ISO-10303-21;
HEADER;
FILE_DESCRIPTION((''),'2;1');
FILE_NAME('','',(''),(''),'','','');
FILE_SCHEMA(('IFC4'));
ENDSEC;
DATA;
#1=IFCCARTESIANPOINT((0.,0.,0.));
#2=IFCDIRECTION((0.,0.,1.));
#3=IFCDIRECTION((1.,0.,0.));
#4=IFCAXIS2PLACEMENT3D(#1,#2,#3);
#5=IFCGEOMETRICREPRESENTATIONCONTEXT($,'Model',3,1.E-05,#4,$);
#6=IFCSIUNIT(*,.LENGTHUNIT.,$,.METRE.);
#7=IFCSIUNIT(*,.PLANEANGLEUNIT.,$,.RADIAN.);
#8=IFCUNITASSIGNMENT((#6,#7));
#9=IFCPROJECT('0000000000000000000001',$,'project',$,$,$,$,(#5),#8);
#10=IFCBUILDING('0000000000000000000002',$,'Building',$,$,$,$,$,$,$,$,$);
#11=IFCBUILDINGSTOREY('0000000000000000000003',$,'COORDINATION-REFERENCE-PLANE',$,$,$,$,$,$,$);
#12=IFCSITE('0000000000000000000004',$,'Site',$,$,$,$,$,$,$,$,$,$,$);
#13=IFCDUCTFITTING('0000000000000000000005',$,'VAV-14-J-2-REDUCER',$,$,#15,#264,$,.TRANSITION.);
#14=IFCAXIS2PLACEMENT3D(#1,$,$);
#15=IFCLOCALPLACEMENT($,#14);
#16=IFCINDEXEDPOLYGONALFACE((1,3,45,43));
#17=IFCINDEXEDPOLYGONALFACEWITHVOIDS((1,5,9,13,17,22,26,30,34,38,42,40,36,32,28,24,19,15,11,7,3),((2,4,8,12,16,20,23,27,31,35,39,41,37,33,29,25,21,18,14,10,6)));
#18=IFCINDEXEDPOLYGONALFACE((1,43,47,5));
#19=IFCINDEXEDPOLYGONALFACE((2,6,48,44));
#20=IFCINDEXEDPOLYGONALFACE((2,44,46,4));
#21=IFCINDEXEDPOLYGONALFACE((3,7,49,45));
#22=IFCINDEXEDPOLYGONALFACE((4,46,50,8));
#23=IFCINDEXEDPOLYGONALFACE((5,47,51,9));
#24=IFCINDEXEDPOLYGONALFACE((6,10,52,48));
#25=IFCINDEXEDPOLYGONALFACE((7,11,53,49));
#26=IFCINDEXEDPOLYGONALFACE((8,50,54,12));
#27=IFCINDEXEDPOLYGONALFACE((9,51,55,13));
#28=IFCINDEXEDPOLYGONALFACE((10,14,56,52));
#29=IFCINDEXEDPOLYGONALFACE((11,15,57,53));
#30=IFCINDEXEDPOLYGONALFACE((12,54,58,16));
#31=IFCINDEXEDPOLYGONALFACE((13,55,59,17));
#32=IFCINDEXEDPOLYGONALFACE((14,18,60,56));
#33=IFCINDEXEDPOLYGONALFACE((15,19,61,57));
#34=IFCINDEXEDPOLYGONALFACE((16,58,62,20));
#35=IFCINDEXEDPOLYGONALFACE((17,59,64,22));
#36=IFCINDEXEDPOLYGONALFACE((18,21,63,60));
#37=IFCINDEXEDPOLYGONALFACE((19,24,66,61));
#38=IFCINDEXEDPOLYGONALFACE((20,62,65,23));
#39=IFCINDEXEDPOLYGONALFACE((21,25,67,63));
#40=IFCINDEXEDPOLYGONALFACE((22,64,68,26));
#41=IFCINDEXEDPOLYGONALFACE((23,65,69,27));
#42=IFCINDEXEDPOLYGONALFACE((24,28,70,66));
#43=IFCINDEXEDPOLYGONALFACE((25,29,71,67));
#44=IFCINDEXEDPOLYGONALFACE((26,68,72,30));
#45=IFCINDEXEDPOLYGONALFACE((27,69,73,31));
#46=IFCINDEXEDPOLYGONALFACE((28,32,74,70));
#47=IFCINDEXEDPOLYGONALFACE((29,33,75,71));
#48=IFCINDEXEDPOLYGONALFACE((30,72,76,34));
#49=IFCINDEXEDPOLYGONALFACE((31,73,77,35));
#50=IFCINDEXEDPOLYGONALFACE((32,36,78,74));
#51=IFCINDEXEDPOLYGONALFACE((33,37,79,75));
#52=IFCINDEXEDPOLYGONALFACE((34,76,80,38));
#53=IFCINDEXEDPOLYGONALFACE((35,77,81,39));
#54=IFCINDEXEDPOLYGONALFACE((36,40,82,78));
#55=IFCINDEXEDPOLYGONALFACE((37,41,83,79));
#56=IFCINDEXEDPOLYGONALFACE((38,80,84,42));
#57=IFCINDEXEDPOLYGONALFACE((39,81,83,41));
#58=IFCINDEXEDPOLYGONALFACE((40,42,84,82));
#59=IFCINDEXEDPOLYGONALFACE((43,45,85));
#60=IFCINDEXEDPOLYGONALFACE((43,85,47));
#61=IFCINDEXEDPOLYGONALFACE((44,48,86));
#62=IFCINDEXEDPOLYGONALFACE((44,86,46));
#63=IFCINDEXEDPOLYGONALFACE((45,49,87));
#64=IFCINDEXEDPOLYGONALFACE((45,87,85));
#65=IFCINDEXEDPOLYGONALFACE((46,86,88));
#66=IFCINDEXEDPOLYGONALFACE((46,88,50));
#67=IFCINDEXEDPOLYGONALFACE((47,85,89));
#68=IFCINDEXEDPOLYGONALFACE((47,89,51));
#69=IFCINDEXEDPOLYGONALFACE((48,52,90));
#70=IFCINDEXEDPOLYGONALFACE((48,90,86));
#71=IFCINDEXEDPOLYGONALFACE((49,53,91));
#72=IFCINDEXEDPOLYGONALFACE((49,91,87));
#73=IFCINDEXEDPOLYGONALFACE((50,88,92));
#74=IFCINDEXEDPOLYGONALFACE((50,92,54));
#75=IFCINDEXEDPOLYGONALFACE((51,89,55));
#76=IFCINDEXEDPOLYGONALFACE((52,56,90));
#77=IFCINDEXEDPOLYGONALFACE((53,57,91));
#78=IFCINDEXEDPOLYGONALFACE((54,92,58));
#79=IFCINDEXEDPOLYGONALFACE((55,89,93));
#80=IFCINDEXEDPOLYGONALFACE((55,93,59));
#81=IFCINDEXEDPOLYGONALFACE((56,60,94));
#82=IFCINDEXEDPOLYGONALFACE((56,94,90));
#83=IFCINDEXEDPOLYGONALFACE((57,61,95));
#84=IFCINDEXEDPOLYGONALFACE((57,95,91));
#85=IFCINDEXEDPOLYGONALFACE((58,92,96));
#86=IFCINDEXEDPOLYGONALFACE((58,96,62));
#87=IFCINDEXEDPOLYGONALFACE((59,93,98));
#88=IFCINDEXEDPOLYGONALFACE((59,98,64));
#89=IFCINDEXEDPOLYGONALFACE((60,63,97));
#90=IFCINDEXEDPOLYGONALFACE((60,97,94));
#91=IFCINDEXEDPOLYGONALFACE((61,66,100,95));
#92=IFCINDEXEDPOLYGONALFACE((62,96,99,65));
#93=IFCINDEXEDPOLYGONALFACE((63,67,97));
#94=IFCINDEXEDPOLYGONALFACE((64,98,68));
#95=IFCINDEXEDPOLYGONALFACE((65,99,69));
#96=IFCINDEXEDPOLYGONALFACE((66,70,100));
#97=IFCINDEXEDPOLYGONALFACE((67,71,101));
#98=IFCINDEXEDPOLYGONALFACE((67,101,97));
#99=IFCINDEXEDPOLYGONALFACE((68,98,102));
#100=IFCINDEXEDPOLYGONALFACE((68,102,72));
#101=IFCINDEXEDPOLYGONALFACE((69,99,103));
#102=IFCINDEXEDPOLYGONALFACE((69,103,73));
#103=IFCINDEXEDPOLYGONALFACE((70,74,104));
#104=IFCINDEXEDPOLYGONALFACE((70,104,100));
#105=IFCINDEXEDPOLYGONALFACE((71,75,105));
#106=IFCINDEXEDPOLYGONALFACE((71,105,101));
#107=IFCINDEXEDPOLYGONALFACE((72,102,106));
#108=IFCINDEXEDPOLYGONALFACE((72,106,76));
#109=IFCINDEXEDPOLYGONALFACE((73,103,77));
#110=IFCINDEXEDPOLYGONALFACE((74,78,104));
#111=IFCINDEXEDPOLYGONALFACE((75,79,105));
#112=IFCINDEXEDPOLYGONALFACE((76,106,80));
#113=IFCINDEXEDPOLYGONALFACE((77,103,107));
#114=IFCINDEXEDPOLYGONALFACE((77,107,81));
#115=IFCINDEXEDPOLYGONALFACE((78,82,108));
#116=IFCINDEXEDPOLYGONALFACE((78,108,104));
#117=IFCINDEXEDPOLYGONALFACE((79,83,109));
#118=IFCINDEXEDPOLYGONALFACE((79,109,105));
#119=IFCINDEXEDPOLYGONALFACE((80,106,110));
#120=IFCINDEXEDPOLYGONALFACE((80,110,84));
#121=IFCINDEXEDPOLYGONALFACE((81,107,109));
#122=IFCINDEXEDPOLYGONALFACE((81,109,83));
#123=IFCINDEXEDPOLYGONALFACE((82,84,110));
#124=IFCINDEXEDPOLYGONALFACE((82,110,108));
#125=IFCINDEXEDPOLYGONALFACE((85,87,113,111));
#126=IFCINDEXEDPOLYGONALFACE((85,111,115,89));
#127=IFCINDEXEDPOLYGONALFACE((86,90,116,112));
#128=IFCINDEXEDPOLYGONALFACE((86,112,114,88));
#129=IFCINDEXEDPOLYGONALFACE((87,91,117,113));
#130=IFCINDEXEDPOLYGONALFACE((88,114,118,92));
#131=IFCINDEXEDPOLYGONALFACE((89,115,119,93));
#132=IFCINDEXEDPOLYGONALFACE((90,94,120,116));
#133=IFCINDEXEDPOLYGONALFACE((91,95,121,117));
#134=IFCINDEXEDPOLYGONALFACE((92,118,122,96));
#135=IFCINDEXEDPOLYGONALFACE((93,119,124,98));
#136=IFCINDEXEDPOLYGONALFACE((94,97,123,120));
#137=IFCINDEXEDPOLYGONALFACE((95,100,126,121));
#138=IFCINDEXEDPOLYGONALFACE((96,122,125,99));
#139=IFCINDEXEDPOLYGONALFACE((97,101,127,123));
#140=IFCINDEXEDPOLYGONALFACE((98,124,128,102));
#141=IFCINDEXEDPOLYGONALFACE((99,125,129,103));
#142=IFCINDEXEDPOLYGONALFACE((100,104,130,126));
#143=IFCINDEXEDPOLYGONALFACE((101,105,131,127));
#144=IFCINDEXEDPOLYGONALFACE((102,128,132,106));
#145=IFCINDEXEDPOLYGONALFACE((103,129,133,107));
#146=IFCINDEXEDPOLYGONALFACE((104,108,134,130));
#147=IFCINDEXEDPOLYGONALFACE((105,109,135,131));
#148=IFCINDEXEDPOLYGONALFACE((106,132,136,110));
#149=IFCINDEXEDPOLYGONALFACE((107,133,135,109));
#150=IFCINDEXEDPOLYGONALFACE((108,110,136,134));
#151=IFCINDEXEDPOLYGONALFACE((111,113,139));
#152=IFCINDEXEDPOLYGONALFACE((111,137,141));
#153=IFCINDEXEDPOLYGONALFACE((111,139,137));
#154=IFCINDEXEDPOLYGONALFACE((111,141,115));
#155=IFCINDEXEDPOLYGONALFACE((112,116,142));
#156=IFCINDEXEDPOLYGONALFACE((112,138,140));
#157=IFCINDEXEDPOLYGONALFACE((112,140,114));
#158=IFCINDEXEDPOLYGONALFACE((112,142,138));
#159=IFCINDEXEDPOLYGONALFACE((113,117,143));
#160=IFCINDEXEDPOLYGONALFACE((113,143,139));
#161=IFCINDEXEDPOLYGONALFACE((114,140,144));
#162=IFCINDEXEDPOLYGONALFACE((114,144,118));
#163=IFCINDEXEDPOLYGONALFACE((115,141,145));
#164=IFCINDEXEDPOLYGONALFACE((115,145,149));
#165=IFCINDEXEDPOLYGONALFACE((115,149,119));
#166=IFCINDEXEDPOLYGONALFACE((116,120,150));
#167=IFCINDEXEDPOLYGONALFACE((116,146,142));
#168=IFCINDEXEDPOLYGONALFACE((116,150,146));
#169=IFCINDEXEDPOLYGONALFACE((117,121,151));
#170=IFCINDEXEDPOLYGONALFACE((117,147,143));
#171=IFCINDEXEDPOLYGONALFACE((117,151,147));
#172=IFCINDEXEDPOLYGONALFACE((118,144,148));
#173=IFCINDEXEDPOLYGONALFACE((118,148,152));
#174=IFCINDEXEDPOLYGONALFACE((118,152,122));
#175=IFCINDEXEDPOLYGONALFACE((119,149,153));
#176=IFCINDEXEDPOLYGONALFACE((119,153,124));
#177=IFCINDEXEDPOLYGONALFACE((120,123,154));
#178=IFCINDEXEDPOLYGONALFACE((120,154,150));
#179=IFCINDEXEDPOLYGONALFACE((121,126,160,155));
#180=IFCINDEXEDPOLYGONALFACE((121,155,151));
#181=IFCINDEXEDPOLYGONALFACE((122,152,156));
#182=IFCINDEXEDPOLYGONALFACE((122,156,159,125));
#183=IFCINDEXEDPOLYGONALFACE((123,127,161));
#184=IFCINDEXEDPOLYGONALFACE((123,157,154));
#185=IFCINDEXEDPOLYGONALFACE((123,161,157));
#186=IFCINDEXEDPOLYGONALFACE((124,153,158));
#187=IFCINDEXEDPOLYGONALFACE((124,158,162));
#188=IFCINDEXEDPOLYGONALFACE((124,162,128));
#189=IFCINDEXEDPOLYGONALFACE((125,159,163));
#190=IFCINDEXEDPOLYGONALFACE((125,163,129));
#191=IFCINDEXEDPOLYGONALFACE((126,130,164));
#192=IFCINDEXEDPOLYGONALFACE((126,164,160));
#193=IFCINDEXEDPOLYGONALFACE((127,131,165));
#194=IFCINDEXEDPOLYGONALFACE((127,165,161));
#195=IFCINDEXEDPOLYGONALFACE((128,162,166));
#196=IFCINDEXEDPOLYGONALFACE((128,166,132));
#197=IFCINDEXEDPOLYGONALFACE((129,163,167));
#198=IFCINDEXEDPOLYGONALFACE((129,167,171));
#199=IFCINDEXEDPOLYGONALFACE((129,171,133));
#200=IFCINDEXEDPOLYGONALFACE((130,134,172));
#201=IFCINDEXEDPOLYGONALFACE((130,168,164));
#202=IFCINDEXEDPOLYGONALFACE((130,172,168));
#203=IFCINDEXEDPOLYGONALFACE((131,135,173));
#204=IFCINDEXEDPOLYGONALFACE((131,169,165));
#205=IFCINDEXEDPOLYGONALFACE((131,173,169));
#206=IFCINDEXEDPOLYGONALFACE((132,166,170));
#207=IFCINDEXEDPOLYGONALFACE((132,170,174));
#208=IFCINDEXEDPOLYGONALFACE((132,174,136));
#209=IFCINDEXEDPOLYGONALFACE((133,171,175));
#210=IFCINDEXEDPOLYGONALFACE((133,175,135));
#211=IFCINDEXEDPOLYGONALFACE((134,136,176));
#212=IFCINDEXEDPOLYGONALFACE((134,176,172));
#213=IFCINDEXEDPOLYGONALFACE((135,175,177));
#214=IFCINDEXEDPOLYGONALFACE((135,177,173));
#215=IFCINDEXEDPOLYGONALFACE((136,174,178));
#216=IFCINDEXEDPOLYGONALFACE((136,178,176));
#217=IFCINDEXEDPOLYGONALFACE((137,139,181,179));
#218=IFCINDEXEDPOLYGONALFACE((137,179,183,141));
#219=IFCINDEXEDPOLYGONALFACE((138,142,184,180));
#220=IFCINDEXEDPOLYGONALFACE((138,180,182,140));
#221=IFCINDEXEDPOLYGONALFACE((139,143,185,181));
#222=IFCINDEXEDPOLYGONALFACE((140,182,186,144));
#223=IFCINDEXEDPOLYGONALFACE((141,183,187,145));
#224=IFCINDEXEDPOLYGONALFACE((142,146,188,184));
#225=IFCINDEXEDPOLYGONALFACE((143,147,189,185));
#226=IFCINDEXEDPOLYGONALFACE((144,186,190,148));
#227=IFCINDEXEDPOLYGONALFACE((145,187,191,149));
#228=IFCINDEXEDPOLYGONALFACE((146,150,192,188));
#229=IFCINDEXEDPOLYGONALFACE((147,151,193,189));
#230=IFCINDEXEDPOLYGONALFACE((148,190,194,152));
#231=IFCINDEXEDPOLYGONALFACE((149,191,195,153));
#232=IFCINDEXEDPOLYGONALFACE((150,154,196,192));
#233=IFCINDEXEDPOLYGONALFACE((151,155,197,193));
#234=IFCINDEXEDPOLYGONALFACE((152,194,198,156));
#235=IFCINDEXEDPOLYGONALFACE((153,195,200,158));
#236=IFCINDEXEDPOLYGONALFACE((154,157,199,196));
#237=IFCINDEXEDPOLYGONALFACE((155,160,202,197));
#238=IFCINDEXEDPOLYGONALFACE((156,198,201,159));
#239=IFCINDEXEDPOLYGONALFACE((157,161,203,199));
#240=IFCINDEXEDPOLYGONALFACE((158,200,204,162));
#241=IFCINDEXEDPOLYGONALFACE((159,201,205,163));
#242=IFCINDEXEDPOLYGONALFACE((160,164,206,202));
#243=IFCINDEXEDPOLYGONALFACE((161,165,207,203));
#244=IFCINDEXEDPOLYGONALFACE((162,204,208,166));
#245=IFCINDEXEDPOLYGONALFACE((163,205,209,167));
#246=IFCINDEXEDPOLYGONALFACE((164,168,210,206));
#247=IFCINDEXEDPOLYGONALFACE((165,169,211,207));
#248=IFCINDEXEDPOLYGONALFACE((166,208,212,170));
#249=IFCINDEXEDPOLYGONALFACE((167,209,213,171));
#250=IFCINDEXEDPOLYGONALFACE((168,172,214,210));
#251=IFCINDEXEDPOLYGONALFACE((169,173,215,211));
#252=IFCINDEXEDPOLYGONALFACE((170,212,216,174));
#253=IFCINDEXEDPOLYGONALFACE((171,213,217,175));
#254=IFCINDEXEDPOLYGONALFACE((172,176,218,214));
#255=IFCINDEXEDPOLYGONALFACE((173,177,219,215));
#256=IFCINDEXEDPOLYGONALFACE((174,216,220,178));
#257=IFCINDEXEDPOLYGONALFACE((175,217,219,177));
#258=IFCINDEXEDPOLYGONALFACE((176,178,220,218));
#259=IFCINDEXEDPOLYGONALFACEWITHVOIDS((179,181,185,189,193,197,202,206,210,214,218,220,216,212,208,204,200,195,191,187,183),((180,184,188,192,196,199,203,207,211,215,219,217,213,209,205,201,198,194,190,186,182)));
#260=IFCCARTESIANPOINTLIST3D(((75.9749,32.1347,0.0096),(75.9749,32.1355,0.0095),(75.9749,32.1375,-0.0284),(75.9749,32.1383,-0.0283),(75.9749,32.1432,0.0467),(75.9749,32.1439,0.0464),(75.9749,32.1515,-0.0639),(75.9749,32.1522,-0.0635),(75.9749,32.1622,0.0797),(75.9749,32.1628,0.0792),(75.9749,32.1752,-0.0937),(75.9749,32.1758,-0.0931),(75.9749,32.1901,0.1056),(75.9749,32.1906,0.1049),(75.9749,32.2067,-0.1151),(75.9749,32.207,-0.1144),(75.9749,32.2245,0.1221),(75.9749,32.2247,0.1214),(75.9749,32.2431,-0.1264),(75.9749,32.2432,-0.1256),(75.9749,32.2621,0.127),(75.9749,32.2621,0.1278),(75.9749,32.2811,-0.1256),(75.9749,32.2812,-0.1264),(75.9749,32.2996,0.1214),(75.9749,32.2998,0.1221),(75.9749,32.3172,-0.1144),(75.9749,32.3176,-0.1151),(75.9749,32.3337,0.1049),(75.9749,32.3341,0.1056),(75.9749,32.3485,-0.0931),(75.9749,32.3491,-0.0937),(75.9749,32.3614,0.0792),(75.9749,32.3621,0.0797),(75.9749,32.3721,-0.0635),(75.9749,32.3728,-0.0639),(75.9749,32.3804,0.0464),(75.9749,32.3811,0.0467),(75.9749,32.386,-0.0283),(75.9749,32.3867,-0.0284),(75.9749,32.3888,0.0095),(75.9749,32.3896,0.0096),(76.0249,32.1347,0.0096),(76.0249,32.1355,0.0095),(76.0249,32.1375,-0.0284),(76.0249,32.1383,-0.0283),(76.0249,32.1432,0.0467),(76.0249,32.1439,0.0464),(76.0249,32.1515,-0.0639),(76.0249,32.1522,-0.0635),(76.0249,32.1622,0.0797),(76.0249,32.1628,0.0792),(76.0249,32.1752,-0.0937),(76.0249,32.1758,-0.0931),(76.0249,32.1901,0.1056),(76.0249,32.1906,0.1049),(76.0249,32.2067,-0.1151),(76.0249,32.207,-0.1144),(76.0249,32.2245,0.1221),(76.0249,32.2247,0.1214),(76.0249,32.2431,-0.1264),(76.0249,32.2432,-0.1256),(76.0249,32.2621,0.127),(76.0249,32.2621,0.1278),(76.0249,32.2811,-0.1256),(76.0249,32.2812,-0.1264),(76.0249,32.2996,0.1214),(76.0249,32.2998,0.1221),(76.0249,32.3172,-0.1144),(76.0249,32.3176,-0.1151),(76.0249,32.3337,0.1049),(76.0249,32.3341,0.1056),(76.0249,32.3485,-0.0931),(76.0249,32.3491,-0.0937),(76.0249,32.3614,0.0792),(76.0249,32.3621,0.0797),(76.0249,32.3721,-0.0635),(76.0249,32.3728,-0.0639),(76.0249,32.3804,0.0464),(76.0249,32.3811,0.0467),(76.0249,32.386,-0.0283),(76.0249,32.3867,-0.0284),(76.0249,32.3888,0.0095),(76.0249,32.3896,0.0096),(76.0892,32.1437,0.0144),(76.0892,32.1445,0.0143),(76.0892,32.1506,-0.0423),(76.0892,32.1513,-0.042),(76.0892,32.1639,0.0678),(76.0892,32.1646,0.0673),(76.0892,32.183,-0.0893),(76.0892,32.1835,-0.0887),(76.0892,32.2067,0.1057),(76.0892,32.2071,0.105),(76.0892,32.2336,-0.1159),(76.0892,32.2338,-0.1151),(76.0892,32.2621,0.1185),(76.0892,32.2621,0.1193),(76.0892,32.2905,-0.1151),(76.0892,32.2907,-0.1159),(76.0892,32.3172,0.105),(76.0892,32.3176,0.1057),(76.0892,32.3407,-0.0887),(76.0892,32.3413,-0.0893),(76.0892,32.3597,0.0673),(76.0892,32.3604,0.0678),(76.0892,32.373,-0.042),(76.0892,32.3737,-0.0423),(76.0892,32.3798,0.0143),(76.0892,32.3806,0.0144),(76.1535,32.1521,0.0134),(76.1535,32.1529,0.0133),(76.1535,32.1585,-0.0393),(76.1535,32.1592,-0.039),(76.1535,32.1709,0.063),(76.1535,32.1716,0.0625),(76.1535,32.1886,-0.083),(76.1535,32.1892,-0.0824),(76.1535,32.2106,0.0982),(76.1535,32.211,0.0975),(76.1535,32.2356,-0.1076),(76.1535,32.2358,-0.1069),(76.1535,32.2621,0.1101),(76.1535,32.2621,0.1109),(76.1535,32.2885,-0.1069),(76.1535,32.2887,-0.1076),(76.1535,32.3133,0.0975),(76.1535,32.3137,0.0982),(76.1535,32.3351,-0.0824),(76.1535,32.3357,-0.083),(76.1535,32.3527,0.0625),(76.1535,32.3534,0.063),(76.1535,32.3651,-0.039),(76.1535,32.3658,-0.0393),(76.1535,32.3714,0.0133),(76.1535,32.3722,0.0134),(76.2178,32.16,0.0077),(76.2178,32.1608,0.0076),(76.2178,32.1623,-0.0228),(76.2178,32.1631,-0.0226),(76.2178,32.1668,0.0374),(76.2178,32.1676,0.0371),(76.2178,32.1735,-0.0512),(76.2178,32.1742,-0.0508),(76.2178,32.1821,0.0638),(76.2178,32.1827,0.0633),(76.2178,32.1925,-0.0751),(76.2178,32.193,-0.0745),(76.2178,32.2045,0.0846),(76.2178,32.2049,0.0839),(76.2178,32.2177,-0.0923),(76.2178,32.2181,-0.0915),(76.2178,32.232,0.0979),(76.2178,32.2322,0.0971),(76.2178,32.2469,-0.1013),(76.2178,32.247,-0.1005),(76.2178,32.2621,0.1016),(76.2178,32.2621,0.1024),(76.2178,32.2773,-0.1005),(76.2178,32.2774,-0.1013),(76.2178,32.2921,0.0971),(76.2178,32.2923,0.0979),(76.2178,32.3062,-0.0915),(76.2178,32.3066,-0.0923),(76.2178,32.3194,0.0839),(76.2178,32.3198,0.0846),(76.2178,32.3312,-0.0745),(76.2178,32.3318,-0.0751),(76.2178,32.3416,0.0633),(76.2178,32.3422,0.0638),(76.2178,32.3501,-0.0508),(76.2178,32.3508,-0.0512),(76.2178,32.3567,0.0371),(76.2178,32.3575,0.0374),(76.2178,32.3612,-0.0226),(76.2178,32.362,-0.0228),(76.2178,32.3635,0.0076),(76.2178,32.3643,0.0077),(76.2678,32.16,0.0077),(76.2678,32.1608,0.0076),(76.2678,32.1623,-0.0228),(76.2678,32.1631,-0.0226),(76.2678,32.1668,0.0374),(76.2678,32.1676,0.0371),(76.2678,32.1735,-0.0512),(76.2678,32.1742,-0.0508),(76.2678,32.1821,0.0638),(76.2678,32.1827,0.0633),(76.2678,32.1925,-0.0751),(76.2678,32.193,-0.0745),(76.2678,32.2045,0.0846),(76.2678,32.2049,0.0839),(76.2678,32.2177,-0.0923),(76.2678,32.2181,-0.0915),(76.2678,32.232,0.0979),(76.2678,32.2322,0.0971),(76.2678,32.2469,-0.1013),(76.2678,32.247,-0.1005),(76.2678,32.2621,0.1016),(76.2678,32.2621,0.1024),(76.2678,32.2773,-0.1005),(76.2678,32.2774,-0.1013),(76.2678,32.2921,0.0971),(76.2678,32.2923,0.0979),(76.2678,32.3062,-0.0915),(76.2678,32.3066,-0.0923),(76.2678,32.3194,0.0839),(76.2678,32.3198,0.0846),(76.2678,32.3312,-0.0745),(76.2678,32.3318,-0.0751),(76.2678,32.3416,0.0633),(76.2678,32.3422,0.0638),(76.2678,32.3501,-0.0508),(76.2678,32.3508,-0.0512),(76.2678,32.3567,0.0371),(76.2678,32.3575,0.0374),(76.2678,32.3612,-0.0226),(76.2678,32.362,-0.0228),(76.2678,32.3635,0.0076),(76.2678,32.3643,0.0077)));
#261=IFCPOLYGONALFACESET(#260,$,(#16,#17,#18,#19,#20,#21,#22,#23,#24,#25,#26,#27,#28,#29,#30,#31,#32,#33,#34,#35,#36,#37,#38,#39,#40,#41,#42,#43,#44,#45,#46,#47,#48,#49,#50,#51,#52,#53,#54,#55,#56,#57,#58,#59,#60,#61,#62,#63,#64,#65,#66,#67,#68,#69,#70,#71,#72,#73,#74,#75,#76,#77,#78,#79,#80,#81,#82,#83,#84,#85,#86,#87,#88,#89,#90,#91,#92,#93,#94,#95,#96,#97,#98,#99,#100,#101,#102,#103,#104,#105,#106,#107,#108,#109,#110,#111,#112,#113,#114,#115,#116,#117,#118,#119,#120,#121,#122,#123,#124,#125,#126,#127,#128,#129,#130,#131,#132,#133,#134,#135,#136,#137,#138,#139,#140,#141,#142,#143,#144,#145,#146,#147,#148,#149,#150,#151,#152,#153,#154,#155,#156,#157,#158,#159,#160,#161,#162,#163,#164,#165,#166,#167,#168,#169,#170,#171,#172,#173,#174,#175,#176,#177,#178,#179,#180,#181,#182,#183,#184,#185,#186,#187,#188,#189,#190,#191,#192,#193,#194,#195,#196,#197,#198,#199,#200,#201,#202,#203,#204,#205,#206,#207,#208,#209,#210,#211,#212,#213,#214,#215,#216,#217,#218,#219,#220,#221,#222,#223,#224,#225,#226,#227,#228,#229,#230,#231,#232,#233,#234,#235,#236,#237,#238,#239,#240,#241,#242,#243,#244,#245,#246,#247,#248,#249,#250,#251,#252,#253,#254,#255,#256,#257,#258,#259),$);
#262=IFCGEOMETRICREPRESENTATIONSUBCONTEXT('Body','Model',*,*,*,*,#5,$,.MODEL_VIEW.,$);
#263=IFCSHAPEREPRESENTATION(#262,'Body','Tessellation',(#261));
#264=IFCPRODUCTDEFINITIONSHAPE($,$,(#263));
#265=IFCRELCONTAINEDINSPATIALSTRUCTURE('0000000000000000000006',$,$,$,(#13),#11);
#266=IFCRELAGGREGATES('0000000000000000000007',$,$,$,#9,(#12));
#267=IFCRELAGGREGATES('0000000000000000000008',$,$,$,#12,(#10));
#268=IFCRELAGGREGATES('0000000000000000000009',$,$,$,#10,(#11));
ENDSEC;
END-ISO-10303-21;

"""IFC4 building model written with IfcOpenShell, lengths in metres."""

from ifc_helpers import new_model, entity, si_unit, frame, origin_with_axes, place, context, subcontext, project, spatial, element, save


model = new_model("IFC4")

# Units and contexts
model_context = context("Model", 3, precision=1e-05, world=origin_with_axes())
body_context_1 = subcontext(model_context, "Body", "Model", "MODEL_VIEW")
ifc_project = project(units=[si_unit("LENGTHUNIT", "METRE"), si_unit("PLANEANGLEUNIT", "RADIAN")], contexts=[model_context])

# Site, building, storey
site = spatial("IfcSite", under=ifc_project, Name="Site")
building = spatial("IfcBuilding", under=site, Name="Building")
storey = spatial("IfcBuildingStorey", under=building, Name="COORDINATION-REFERENCE-PLANE")

# Duct fitting
for number, where, z_axis, x_axis, name in (
    (1, (75.9749, 32.2621, 0.0), (0.0, 1.0, 0.0), (0.0, 0.0, 1.0), "VAV-14-J-2-REDUCER"),
):
    element("IfcDuctFitting", number, at=place(None, frame(where, z_axis=z_axis, x_axis=x_axis)), inside=storey, Name=name, PredefinedType="TRANSITION", context=body_context_1, shape_type="SweptSolid", body=[
        entity("IfcRevolvedAreaSolid", entity("IfcArbitraryClosedProfileDef", "AREA", None, entity("IfcPolyline", [entity("IfcCartesianPoint", [0.1278, 0.0]), entity("IfcCartesianPoint", [0.1278, 0.05]), entity("IfcCartesianPoint", [0.1024, 0.2429]), entity("IfcCartesianPoint", [0.1024, 0.2929]), entity("IfcCartesianPoint", [0.1016, 0.2929]), entity("IfcCartesianPoint", [0.1016, 0.2429]), entity("IfcCartesianPoint", [0.127, 0.05]), entity("IfcCartesianPoint", [0.127, 0.0]), entity("IfcCartesianPoint", [0.1278, 0.0])])), entity("IfcAxis2Placement3D", entity("IfcCartesianPoint", [0.0, 0.0, 0.0])), entity("IfcAxis1Placement", entity("IfcCartesianPoint", [0.0, 0.0, 0.0]), entity("IfcDirection", [0.0, 1.0, 0.0])), 6.283185),
    ])

save(model, "model.ifc")
